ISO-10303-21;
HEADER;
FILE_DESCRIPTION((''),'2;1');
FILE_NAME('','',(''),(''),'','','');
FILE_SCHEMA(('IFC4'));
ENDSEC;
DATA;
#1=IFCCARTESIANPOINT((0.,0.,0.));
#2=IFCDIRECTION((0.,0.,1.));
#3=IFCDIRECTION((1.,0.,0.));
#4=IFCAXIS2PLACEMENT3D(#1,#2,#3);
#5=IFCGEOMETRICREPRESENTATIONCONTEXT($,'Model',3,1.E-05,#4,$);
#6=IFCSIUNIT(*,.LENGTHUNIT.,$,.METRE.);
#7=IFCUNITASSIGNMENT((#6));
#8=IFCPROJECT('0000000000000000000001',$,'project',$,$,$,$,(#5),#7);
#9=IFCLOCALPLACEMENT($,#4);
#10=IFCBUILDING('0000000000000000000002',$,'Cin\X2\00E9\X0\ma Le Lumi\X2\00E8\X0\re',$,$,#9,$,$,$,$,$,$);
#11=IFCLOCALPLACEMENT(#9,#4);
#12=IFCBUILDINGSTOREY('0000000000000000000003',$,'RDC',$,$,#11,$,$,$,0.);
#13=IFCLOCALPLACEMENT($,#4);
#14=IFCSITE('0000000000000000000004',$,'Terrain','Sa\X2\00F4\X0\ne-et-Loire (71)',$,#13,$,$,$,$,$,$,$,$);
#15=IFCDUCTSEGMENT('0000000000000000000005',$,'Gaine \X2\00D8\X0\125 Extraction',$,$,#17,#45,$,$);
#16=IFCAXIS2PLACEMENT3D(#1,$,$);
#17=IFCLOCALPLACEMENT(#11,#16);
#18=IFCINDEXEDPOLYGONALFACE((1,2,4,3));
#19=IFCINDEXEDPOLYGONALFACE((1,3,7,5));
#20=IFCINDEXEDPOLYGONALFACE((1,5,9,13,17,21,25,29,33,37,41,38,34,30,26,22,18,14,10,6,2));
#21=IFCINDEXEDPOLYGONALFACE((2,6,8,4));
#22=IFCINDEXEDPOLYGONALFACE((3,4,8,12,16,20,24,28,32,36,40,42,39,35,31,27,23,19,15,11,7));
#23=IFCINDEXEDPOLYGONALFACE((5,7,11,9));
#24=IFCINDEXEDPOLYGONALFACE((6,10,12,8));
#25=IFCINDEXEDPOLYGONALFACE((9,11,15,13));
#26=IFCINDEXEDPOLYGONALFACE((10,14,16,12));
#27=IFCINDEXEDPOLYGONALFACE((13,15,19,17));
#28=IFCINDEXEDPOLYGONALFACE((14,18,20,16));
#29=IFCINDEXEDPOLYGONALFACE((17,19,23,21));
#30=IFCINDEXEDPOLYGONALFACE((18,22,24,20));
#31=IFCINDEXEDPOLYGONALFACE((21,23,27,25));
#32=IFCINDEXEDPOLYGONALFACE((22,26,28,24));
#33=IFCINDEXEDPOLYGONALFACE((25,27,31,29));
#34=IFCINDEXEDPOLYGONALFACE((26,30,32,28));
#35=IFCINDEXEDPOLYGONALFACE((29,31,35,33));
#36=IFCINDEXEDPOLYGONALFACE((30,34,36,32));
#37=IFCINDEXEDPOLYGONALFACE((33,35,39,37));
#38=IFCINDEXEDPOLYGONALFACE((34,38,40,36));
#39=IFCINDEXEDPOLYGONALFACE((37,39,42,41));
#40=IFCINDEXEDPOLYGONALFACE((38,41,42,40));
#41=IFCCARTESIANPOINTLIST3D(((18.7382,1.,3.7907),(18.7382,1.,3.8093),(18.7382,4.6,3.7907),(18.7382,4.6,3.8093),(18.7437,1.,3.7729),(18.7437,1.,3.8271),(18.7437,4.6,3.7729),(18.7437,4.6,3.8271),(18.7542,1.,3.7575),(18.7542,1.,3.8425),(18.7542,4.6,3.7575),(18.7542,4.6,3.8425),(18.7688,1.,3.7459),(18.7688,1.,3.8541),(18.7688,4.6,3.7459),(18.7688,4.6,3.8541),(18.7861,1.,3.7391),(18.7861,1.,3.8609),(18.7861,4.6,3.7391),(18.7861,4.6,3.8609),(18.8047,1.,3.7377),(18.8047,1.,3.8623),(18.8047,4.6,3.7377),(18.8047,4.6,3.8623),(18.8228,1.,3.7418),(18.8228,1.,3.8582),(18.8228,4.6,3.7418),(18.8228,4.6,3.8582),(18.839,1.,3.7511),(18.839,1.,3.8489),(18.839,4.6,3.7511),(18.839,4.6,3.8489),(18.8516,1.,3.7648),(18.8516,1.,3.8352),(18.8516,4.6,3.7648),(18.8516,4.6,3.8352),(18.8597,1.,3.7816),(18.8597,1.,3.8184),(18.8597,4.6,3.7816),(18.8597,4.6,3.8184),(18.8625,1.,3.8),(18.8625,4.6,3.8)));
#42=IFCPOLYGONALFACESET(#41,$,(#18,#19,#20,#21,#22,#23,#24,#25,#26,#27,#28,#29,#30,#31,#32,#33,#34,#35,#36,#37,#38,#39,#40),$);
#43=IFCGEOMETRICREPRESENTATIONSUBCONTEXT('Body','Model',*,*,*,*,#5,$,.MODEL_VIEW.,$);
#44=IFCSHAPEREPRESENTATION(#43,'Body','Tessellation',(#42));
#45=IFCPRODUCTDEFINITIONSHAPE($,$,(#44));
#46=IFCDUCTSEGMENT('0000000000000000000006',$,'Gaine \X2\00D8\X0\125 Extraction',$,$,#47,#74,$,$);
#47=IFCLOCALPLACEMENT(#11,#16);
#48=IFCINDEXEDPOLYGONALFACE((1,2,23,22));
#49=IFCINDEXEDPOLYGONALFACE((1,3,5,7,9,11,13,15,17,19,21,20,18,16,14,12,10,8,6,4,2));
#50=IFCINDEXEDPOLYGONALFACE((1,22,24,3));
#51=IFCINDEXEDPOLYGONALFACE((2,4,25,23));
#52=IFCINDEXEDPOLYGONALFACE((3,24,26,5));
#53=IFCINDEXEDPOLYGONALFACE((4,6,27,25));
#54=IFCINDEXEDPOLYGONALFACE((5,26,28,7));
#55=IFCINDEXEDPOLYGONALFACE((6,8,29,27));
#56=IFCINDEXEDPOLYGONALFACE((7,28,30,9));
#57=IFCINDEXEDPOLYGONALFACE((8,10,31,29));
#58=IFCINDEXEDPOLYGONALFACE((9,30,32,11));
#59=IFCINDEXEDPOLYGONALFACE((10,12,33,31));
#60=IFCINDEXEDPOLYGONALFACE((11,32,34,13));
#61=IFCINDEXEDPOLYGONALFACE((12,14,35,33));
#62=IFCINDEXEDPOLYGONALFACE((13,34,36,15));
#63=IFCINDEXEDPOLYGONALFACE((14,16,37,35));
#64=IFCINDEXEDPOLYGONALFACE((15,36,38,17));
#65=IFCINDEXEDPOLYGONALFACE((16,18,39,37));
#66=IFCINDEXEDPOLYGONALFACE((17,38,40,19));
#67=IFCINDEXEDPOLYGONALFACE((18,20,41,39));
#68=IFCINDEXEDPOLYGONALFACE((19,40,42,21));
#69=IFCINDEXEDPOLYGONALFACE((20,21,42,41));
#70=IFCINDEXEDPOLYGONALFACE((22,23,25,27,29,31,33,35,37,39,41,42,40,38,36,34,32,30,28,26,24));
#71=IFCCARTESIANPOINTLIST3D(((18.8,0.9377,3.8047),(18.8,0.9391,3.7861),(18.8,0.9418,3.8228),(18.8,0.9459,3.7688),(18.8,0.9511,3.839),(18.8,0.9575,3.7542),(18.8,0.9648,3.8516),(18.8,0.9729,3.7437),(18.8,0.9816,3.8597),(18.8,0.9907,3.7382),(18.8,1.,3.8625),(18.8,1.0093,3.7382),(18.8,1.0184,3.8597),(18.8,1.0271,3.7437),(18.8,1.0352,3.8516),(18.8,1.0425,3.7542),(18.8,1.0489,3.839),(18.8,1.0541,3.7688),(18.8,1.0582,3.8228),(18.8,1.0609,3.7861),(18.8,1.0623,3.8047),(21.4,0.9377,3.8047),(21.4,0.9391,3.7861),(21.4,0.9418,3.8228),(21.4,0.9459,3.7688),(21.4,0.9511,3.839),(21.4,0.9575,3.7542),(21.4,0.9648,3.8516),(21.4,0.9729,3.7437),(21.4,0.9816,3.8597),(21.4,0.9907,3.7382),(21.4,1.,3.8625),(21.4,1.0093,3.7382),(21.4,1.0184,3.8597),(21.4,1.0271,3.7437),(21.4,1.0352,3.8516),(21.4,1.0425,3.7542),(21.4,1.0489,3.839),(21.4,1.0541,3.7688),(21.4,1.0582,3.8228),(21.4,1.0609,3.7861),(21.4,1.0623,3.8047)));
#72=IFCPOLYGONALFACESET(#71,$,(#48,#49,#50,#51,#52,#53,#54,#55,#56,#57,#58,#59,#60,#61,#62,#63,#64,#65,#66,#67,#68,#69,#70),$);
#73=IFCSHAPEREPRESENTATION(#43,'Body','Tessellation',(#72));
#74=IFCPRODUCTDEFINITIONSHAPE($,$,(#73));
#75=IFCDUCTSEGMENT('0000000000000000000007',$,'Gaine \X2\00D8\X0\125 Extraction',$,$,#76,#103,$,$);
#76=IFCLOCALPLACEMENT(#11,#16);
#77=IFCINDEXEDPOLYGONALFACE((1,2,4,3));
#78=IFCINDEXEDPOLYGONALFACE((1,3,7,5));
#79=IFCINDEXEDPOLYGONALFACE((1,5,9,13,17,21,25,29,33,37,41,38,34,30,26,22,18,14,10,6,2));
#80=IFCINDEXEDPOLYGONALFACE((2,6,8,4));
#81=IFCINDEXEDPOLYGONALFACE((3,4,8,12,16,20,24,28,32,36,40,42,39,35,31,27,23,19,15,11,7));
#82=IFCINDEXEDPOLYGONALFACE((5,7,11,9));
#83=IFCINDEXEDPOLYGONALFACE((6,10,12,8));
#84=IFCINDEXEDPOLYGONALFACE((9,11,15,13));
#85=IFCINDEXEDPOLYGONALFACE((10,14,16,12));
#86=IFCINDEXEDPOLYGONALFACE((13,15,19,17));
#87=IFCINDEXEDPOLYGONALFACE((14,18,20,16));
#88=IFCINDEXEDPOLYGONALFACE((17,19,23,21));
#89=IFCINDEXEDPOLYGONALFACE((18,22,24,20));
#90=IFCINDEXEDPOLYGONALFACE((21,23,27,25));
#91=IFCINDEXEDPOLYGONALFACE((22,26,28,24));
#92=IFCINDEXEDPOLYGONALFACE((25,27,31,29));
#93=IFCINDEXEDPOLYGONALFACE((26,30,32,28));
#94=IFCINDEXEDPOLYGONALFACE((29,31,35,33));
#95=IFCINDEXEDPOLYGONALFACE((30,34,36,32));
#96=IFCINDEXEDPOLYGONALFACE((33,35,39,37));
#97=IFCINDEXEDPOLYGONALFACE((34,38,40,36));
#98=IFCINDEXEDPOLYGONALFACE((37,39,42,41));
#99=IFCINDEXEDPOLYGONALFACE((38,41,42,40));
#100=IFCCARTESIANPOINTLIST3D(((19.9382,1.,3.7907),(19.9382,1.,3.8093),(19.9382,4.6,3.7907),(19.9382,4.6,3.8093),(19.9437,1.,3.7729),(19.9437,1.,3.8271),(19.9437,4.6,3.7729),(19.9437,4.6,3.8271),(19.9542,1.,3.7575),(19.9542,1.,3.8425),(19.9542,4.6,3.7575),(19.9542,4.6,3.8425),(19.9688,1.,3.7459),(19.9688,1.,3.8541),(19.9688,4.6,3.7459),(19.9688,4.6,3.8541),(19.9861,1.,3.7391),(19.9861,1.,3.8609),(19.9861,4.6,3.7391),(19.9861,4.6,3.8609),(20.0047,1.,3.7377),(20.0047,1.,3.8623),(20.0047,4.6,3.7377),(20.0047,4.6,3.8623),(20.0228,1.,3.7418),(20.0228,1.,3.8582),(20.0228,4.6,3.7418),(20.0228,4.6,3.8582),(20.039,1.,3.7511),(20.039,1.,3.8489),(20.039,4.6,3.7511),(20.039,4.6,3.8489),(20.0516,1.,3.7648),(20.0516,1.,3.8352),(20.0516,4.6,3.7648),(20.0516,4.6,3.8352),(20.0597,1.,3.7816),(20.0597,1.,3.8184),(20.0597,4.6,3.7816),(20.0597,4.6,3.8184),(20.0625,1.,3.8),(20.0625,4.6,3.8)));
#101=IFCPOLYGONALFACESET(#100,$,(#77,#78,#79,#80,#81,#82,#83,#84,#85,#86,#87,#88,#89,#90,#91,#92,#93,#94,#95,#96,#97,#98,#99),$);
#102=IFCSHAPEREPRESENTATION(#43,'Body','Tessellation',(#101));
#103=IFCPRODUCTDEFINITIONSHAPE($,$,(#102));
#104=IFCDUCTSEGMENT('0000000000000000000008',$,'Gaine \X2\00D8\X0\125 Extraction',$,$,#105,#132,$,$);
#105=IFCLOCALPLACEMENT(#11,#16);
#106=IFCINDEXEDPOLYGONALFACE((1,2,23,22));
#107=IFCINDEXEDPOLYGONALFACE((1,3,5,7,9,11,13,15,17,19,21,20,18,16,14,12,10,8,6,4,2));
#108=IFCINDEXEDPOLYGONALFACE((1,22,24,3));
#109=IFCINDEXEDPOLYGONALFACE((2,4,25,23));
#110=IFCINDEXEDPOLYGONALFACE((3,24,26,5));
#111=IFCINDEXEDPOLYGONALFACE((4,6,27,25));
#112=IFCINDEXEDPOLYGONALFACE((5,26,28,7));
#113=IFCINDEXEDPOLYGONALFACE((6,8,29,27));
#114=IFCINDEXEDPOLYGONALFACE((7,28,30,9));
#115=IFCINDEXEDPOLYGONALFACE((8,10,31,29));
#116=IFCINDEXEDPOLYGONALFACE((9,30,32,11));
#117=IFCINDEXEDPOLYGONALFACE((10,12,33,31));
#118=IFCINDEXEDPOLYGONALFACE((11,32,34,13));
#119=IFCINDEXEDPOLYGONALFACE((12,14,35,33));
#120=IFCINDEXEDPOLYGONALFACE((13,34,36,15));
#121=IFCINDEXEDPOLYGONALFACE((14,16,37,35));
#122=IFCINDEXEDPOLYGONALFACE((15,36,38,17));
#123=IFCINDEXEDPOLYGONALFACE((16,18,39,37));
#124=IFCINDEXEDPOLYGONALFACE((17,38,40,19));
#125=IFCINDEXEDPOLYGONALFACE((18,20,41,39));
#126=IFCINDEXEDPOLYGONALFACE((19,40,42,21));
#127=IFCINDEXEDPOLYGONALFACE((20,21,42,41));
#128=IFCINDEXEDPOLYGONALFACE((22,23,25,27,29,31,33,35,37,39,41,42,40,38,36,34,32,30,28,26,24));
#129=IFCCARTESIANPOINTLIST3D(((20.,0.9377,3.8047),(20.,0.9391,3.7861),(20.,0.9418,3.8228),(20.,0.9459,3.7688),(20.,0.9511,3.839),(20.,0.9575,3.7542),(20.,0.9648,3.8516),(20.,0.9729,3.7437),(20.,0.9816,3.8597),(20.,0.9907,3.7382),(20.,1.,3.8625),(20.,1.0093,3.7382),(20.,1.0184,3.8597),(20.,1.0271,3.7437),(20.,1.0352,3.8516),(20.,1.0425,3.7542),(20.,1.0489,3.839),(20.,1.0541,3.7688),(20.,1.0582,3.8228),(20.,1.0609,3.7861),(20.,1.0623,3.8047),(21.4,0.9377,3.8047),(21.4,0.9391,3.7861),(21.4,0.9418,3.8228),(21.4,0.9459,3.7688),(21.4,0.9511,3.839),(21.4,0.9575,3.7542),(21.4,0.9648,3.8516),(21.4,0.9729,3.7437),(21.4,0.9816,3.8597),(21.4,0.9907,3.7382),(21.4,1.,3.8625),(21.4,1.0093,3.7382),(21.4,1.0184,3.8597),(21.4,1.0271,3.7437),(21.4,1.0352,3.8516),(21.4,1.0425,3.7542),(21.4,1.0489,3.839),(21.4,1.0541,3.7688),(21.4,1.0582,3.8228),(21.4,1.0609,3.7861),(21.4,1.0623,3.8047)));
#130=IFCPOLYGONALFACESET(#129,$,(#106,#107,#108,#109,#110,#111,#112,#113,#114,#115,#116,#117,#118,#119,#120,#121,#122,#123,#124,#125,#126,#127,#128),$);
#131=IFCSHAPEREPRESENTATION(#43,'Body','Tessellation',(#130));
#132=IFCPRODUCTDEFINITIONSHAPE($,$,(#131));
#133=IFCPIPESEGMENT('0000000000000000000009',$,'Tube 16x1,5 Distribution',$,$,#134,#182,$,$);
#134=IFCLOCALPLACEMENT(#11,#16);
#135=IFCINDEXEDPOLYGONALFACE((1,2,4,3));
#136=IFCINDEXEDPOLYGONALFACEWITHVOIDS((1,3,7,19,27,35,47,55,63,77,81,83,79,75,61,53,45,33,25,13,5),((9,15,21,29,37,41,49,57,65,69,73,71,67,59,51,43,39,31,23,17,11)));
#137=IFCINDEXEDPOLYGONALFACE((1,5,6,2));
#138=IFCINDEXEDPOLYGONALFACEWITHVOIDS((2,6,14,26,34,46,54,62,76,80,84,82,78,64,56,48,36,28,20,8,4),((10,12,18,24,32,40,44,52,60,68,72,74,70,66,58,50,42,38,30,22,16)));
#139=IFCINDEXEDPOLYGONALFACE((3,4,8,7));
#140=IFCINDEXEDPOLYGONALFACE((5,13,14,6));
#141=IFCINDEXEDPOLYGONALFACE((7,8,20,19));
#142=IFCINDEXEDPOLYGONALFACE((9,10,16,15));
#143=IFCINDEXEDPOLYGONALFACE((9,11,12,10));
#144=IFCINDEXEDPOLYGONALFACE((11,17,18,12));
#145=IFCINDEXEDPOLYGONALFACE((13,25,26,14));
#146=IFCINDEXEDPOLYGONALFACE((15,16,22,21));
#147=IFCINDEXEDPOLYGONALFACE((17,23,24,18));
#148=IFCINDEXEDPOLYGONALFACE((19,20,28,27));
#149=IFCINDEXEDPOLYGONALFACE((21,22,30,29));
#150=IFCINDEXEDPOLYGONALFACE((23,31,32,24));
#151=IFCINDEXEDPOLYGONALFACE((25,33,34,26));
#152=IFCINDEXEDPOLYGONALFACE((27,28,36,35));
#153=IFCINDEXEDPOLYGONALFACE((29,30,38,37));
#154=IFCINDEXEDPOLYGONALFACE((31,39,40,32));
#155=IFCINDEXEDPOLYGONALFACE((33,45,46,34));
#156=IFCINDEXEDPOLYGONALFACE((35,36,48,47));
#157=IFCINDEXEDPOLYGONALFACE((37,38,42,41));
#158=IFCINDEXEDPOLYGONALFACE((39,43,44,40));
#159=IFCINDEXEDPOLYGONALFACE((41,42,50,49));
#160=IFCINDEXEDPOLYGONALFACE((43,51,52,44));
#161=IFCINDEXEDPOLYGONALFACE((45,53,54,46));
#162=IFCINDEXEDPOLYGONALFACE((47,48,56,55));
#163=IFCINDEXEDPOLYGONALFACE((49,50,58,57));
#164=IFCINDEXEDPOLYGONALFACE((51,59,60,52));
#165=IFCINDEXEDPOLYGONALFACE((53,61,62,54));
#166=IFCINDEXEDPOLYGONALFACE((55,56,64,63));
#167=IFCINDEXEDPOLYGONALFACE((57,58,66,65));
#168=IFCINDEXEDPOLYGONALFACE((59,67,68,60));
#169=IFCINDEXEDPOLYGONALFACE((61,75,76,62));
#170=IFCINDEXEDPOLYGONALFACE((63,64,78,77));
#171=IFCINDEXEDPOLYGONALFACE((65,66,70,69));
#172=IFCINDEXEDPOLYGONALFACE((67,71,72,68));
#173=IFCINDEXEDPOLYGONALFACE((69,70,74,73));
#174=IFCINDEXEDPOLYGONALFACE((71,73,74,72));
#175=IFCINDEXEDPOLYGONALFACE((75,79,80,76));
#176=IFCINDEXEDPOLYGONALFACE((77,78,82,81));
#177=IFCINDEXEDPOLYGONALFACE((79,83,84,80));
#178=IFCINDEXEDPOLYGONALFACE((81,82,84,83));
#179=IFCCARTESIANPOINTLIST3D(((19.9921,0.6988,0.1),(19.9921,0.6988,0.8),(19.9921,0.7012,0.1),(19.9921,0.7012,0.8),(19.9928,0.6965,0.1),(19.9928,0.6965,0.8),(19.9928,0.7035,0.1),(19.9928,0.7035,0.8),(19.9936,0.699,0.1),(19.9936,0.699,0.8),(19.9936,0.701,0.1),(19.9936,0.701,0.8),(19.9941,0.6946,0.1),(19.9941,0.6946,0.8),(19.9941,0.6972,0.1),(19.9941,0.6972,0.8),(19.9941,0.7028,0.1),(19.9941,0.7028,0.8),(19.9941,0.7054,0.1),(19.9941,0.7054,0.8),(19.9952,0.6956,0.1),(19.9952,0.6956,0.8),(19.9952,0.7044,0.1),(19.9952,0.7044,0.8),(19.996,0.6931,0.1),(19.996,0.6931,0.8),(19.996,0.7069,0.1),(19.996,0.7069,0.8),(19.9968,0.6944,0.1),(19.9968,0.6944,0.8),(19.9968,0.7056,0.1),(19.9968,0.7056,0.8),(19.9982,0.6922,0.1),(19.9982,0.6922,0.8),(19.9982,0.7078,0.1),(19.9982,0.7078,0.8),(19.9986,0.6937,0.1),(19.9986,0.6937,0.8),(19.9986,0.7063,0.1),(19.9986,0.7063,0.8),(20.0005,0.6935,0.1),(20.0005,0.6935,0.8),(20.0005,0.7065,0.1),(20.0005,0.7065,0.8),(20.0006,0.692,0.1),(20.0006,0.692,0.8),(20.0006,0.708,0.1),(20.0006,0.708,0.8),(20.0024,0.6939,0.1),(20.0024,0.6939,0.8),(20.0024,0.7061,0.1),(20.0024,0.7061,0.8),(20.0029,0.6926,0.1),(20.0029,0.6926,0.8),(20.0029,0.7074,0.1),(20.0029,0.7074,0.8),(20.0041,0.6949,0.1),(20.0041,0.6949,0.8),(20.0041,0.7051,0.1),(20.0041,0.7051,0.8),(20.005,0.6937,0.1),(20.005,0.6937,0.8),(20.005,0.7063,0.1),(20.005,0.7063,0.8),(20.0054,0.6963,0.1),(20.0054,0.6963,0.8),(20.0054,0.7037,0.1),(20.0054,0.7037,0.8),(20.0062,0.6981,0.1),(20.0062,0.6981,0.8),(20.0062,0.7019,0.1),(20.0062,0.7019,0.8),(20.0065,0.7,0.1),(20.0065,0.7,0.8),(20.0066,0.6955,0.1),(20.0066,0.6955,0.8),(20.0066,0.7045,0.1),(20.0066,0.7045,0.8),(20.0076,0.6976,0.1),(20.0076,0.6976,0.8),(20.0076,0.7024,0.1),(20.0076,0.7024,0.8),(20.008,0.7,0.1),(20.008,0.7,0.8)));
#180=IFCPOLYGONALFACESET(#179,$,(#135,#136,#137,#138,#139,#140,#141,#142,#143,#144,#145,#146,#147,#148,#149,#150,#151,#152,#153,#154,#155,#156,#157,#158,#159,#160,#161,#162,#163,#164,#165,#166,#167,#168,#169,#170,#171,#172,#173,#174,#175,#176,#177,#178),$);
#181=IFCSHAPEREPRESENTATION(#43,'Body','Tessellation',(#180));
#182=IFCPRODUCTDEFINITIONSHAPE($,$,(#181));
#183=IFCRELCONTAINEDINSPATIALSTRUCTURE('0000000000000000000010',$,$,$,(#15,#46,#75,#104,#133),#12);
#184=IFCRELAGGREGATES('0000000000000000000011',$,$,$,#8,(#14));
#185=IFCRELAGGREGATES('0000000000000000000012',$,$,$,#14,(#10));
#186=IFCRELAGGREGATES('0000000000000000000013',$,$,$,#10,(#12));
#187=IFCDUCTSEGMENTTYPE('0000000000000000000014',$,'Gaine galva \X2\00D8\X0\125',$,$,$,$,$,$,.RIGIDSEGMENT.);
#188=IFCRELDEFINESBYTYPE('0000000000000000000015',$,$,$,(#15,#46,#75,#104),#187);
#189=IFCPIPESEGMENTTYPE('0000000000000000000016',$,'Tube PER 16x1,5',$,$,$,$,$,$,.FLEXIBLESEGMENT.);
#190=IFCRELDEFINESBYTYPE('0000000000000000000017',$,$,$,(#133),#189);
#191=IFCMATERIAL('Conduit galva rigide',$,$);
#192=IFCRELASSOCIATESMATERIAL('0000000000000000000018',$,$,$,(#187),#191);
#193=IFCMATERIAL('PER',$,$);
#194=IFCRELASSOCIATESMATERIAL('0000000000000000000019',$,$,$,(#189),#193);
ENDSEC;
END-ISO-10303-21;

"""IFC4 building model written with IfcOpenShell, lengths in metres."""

from ifc_helpers import new_model, si_unit, frame, origin_with_axes, place, context, subcontext, project, spatial, circle, hollow_circle, extrude, material, type_object, element, save


model = new_model("IFC4")

# Units and contexts
model_context = context("Model", 3, precision=1e-05, world=origin_with_axes())
body_context = subcontext(model_context, "Body", "Model", "MODEL_VIEW")
ifc_project = project(units=[si_unit("LENGTHUNIT", "METRE")], contexts=[model_context])

# Site, building, storey
site_placement = place(None, origin_with_axes())
site = spatial("IfcSite", under=ifc_project, at=site_placement, Name="Terrain", Description="Saône-et-Loire (71)")
building_placement = place(None, origin_with_axes())
building = spatial("IfcBuilding", under=site, at=building_placement, Name="Cinéma Le Lumière")
storey_placement = place(building_placement, origin_with_axes())
storey = spatial("IfcBuildingStorey", under=building, at=storey_placement, Name="RDC", Elevation=0.0)

# Duct segments
ifc_material_1 = material(Name="Conduit galva rigide")
duct_segment_type = type_object("IfcDuctSegmentType", Name="Gaine galva Ø125", PredefinedType="RIGIDSEGMENT", material=ifc_material_1)
duct_segment_1_placement = place(storey_placement, frame((18.8, 4.6, 3.8), z_axis=(0.0, -1.0, 0.0), x_axis=(1.0, 0.0, 0.0)))
element("IfcDuctSegment", 1, at=duct_segment_1_placement, inside=storey, type_object=duct_segment_type, Name="Gaine Ø125 Extraction", context=body_context, shape_type="SweptSolid", body=[
    extrude(circle(Radius=0.0625), origin_with_axes(), (0.0, 0.0, 1.0), 3.6),
])
duct_segment_2_placement = place(storey_placement, frame((18.8, 1.0, 3.8), z_axis=(1.0, 0.0, 0.0), x_axis=(0.0, 0.0, 1.0)))
element("IfcDuctSegment", 2, at=duct_segment_2_placement, inside=storey, type_object=duct_segment_type, Name="Gaine Ø125 Extraction", context=body_context, shape_type="SweptSolid", body=[
    extrude(circle(Radius=0.0625), origin_with_axes(), (0.0, 0.0, 1.0), 2.6),
])
duct_segment_3_placement = place(storey_placement, frame((20.0, 4.6, 3.8), z_axis=(0.0, -1.0, 0.0), x_axis=(1.0, 0.0, 0.0)))
element("IfcDuctSegment", 3, at=duct_segment_3_placement, inside=storey, type_object=duct_segment_type, Name="Gaine Ø125 Extraction", context=body_context, shape_type="SweptSolid", body=[
    extrude(circle(Radius=0.0625), origin_with_axes(), (0.0, 0.0, 1.0), 3.6),
])
duct_segment_4_placement = place(storey_placement, frame((20.0, 1.0, 3.8), z_axis=(1.0, 0.0, 0.0), x_axis=(0.0, 0.0, 1.0)))
element("IfcDuctSegment", 4, at=duct_segment_4_placement, inside=storey, type_object=duct_segment_type, Name="Gaine Ø125 Extraction", context=body_context, shape_type="SweptSolid", body=[
    extrude(circle(Radius=0.0625), origin_with_axes(), (0.0, 0.0, 1.0), 1.4),
])

# Pipe segment
ifc_material_2 = material(Name="PER")
pipe_segment_type = type_object("IfcPipeSegmentType", Name="Tube PER 16x1,5", PredefinedType="FLEXIBLESEGMENT", material=ifc_material_2)
pipe_segment_1_placement = place(storey_placement, frame((20.0, 0.7, 0.1), z_axis=(0.0, 0.0, 1.0), x_axis=(1.0, 0.0, 0.0)))
element("IfcPipeSegment", 5, at=pipe_segment_1_placement, inside=storey, type_object=pipe_segment_type, Name="Tube 16x1,5 Distribution", context=body_context, shape_type="SweptSolid", body=[
    extrude(hollow_circle(Radius=0.008, WallThickness=0.0015), origin_with_axes(), (0.0, 0.0, 1.0), 0.7),
])

save(model, "model.ifc")
